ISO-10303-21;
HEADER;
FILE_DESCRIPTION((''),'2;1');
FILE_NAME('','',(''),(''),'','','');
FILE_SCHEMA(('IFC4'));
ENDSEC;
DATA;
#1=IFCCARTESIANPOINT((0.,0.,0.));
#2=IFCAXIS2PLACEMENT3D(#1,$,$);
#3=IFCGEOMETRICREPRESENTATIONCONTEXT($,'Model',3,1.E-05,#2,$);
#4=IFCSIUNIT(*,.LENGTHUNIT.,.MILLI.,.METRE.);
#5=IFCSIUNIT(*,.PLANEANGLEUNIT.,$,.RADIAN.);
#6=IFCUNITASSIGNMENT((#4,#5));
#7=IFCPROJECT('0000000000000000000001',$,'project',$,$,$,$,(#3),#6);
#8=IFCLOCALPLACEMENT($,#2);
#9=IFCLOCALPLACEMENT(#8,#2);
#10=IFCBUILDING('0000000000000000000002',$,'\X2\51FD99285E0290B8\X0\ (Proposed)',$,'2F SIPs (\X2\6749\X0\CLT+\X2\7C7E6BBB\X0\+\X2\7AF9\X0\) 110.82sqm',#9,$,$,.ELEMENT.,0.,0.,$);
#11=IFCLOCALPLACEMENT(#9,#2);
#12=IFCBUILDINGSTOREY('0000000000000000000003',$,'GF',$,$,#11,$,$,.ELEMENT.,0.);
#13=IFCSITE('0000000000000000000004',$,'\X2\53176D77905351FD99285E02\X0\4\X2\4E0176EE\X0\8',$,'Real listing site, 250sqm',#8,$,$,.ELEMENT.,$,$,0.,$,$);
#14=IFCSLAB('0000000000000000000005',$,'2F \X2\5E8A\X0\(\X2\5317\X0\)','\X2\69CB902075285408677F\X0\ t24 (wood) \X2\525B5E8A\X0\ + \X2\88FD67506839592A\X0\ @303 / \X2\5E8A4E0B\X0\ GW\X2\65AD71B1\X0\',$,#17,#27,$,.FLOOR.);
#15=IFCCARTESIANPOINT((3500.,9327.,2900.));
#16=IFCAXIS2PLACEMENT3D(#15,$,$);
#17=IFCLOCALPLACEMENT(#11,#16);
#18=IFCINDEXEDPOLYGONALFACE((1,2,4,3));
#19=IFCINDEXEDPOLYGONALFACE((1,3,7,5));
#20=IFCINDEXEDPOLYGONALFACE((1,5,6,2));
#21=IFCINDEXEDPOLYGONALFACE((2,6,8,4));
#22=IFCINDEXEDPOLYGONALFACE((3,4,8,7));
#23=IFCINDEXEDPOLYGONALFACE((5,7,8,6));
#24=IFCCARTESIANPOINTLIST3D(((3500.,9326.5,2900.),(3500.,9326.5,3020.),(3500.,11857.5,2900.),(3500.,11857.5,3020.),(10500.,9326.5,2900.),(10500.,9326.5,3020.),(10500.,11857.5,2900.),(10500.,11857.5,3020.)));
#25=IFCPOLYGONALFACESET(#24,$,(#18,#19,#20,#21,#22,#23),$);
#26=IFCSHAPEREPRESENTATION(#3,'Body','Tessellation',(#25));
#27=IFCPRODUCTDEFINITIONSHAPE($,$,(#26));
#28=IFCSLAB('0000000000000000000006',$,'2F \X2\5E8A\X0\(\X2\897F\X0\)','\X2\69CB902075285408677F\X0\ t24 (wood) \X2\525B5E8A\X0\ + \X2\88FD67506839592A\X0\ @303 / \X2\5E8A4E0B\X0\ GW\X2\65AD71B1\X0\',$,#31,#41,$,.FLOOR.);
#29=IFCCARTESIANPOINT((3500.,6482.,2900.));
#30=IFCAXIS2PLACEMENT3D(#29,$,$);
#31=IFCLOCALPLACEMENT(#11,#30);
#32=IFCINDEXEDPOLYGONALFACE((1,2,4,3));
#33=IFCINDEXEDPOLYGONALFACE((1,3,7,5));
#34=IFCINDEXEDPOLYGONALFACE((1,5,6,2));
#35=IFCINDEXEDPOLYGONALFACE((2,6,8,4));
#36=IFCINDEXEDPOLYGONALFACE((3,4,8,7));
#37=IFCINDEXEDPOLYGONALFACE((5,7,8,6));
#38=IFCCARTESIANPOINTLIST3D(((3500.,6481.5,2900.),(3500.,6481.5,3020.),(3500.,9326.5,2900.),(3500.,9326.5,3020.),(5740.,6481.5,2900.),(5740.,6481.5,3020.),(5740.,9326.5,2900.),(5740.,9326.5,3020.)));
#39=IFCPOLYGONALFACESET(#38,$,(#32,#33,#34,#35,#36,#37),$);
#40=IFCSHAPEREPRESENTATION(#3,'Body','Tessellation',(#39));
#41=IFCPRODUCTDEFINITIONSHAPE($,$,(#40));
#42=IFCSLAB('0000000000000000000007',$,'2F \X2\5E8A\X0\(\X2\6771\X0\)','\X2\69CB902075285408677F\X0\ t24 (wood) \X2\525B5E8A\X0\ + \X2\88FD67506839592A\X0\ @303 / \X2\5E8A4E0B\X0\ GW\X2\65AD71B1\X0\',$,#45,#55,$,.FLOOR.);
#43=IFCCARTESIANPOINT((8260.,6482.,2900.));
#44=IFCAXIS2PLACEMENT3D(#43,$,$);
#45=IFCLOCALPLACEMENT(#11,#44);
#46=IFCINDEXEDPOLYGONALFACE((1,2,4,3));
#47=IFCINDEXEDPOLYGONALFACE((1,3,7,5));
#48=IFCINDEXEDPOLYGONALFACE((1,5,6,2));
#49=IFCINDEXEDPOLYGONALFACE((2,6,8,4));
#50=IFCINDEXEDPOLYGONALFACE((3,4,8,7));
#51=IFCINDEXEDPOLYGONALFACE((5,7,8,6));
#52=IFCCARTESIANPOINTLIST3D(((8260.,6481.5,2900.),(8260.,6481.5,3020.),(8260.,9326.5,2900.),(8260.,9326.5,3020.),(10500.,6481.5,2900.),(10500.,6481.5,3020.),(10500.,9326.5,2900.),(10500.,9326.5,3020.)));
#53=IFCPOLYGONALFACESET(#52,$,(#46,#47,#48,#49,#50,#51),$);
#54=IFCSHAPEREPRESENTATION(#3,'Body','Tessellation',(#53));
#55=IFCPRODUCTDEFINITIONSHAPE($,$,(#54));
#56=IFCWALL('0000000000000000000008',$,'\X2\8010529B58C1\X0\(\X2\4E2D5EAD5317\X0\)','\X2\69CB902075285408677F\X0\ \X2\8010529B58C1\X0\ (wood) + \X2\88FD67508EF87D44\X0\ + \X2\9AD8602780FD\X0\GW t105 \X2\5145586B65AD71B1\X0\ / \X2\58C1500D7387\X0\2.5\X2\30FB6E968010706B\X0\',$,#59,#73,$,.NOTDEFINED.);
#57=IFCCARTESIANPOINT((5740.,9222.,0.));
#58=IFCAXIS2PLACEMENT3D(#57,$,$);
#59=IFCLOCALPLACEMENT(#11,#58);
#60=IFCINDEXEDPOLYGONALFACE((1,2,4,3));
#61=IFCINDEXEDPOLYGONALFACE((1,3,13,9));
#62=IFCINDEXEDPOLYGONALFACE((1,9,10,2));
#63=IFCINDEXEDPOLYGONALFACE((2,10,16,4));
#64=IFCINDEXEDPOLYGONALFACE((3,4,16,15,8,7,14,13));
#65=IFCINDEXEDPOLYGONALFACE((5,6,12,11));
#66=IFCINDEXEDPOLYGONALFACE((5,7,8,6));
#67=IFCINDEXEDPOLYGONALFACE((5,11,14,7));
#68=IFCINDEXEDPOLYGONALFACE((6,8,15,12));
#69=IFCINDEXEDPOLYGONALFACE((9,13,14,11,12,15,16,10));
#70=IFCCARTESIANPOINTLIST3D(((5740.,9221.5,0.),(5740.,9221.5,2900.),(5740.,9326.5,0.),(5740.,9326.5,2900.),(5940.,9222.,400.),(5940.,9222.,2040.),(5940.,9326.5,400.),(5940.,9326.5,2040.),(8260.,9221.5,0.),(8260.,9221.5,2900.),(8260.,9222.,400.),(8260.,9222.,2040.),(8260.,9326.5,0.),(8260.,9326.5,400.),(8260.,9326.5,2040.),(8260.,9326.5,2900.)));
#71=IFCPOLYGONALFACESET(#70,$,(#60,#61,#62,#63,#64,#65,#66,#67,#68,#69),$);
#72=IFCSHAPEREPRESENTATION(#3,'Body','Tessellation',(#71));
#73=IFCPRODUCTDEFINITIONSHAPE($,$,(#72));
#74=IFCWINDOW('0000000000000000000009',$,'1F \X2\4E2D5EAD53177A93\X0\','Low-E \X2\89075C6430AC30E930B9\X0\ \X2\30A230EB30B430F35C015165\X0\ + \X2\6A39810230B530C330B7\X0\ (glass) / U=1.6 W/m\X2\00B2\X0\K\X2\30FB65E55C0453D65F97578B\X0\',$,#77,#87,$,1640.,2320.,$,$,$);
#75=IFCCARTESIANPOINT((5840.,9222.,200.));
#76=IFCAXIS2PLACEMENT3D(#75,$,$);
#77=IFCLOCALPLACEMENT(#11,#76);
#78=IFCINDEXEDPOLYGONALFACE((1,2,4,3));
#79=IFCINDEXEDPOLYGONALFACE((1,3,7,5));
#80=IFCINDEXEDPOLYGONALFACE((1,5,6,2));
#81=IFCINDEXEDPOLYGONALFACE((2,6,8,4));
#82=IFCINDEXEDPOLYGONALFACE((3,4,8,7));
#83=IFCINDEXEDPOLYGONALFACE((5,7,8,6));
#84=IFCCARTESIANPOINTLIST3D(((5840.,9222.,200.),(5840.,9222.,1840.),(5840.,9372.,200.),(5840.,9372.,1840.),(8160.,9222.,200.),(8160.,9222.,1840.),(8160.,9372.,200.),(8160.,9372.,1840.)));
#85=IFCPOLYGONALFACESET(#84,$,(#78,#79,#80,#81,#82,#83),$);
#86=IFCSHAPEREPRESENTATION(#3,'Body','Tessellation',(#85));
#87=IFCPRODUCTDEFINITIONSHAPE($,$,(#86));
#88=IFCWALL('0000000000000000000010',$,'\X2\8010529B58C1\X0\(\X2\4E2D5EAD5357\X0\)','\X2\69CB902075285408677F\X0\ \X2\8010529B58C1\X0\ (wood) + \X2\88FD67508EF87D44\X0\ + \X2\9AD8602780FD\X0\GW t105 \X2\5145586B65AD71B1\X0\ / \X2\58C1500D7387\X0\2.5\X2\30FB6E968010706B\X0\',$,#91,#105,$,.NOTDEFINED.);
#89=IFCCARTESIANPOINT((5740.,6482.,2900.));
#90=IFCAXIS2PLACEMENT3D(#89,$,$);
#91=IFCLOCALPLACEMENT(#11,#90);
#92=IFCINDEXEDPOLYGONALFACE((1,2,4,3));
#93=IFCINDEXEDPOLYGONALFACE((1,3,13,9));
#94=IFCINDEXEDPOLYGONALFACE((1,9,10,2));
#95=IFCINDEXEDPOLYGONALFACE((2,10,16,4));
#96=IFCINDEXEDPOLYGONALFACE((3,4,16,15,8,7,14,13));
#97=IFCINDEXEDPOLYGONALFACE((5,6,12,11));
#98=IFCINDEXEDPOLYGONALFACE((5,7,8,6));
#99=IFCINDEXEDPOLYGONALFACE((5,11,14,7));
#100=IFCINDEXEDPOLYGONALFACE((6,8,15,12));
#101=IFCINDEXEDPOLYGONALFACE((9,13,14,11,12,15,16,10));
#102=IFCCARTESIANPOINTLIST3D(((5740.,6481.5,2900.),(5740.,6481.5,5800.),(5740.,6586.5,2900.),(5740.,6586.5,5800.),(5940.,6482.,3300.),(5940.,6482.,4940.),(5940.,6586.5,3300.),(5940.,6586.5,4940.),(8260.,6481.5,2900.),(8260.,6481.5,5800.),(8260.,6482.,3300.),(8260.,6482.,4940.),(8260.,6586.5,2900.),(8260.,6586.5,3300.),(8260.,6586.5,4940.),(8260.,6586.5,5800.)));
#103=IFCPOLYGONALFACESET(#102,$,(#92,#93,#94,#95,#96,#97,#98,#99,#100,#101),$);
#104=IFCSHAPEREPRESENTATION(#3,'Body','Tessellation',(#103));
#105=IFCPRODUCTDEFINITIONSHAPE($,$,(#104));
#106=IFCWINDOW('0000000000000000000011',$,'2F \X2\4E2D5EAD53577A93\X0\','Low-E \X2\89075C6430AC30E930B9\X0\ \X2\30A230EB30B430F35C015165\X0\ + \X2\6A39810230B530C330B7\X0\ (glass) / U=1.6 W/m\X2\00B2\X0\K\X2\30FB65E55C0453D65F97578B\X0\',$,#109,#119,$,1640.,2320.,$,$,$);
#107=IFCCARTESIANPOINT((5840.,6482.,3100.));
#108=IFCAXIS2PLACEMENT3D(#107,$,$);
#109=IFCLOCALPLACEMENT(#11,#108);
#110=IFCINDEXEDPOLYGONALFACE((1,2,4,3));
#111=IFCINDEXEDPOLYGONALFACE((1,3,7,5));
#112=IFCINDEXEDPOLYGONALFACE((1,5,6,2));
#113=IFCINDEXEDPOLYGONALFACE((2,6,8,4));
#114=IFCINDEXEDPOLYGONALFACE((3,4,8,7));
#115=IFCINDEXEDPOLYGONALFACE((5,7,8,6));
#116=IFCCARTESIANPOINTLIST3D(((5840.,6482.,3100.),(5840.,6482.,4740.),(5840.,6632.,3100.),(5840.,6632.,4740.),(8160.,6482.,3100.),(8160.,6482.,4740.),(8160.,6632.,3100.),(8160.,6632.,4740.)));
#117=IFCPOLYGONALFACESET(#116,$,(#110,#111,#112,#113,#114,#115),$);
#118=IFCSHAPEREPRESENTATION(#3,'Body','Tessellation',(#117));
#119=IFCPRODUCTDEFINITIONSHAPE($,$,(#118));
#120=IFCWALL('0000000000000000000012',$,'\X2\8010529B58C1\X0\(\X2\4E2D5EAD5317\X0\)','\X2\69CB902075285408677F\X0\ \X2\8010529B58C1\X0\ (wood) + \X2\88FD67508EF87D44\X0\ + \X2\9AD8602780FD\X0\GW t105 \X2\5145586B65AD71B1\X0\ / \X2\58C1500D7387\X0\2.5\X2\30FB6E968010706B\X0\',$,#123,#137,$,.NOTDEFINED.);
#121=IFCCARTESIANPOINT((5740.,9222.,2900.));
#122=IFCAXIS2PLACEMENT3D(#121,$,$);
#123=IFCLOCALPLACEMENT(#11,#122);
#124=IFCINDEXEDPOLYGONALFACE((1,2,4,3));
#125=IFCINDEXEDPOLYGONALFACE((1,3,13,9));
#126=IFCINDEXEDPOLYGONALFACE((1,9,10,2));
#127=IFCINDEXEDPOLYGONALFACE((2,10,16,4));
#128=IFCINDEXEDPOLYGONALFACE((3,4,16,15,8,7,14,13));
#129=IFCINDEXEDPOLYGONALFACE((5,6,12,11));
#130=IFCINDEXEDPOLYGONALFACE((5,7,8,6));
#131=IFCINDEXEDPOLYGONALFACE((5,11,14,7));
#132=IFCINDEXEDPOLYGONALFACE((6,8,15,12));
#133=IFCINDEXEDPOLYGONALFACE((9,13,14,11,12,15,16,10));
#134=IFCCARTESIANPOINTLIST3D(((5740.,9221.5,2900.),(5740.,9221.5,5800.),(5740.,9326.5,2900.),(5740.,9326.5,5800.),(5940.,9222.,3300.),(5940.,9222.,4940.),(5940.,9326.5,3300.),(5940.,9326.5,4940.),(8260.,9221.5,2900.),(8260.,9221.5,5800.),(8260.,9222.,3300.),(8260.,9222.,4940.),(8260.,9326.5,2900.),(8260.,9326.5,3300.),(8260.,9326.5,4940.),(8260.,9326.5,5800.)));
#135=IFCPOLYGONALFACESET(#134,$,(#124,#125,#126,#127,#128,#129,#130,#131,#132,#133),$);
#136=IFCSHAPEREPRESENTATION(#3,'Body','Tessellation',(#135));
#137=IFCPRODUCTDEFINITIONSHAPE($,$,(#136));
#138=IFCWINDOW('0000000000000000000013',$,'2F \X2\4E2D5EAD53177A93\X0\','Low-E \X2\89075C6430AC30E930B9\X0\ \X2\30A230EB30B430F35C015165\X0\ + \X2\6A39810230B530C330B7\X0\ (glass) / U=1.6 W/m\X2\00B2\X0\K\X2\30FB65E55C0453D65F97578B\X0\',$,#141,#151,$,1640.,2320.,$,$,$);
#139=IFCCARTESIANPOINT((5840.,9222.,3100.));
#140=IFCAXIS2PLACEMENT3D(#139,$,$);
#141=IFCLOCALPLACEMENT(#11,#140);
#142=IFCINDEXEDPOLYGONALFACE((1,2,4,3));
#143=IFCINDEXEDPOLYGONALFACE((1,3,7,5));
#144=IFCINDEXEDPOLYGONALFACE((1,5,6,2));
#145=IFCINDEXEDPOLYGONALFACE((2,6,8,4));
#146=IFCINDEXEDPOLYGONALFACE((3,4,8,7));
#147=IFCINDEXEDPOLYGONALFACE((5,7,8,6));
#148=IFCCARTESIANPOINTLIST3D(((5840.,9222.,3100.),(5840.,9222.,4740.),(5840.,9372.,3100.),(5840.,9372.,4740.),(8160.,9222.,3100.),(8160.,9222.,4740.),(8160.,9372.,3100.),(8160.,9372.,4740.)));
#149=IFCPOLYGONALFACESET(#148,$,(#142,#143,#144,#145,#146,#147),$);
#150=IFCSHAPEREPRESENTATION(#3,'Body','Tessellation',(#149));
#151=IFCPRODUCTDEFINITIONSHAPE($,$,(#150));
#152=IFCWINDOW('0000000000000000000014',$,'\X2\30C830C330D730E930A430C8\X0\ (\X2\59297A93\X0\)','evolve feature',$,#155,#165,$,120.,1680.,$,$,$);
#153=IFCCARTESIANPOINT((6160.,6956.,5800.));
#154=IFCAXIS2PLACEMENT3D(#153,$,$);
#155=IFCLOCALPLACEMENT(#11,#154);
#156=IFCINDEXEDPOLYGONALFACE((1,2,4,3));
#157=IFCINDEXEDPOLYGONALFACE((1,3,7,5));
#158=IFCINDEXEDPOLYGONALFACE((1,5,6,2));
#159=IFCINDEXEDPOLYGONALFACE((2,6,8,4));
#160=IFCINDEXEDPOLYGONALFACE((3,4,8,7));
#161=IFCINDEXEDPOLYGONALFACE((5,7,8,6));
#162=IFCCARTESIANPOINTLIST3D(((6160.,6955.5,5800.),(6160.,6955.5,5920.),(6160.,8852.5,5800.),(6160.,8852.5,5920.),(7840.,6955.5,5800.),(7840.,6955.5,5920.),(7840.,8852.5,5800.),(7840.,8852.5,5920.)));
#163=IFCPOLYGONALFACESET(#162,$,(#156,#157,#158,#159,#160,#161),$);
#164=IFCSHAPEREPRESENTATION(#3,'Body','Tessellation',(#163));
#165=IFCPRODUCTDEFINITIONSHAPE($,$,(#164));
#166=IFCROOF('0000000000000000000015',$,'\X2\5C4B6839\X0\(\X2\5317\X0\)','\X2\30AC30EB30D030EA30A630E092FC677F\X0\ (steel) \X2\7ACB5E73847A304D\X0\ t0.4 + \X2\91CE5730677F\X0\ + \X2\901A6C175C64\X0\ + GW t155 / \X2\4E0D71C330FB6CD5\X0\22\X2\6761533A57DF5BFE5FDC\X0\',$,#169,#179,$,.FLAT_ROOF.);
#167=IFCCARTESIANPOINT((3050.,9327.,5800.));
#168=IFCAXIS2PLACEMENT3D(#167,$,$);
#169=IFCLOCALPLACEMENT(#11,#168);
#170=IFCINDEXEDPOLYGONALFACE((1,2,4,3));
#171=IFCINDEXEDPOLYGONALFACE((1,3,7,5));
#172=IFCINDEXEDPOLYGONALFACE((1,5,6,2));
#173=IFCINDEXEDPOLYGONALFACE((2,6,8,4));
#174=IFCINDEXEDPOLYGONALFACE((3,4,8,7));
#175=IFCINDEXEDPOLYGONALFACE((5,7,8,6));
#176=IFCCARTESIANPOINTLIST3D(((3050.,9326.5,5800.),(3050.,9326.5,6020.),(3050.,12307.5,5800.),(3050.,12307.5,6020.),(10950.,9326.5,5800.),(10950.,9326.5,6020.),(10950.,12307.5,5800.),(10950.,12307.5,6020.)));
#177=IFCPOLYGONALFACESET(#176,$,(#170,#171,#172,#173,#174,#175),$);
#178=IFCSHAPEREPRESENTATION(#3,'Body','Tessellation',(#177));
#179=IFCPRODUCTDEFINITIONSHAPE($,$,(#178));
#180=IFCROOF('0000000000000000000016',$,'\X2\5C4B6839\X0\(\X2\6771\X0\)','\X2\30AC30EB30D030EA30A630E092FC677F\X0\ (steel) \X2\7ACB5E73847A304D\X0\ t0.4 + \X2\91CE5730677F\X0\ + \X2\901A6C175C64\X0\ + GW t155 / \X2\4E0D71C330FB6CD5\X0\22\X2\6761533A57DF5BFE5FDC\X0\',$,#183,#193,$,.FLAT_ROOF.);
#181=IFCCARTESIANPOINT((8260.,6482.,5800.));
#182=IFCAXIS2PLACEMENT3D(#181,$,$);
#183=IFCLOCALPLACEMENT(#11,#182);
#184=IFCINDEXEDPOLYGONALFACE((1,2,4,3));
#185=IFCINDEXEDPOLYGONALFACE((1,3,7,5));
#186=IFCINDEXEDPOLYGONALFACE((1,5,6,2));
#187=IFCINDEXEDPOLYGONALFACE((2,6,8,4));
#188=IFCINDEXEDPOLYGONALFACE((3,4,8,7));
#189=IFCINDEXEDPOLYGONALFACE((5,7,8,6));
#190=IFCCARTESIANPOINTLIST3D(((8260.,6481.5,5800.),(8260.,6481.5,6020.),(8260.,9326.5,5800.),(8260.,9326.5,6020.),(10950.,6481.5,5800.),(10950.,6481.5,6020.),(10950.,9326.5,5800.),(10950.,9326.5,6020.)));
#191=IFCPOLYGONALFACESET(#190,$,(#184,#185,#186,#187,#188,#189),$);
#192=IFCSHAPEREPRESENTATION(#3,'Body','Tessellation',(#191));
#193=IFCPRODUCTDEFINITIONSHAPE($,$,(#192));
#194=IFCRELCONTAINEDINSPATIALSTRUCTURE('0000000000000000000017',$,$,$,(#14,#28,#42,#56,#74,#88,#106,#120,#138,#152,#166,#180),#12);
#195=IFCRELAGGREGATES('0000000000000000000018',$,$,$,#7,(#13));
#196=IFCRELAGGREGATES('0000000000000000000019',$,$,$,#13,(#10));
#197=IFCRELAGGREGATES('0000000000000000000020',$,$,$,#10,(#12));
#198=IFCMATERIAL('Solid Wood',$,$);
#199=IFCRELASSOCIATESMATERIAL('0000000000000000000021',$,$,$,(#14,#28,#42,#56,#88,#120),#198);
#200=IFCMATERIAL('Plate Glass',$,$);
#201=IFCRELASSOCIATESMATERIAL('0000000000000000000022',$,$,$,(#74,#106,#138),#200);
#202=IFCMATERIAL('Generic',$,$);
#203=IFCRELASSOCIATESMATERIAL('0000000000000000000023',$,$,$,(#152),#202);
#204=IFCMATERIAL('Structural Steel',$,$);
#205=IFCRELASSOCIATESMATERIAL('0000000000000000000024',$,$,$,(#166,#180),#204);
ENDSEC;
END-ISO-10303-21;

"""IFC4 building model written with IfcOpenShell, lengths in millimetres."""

from ifc_helpers import new_model, si_unit, frame, frame_2d, origin, place, context, project, spatial, rectangle, extrude, material, element, fill, save


model = new_model("IFC4")

# Units and contexts
model_context = context("Model", 3, precision=1e-05, world=origin())
ifc_project = project(units=[si_unit("LENGTHUNIT", "METRE", prefix="MILLI"), si_unit("PLANEANGLEUNIT", "RADIAN")], contexts=[model_context])

# Site, building, storey
site_placement = place(None, origin())
site = spatial("IfcSite", under=ifc_project, at=site_placement, Name="北海道函館市4丁目8", ObjectType="Real listing site, 250sqm", CompositionType="ELEMENT", RefElevation=0.0)
building_placement = place(site_placement, origin())
building = spatial("IfcBuilding", under=site, at=building_placement, Name="函館市邸 (Proposed)", ObjectType="2F SIPs (杉CLT+籾殻+竹) 110.82sqm", CompositionType="ELEMENT", ElevationOfRefHeight=0.0, ElevationOfTerrain=0.0)
storey_placement = place(building_placement, origin())
storey = spatial("IfcBuildingStorey", under=building, at=storey_placement, Name="GF", CompositionType="ELEMENT", Elevation=0.0)

# Slabs
ifc_material_1 = material(Name="Solid Wood")
slab_1_placement = place(storey_placement, frame((3500.0, 9327.0, 2900.0)))
element("IfcSlab", 1, at=slab_1_placement, inside=storey, material=ifc_material_1, Name="2F 床(北)", Description="構造用合板 t24 (wood) 剛床 + 製材根太 @303 / 床下 GW断熱", PredefinedType="FLOOR", context=model_context, shape_type="SweptSolid", body=[
    extrude(rectangle(XDim=7000.0, YDim=2531.0, at=frame_2d((3500.0, 1265.0))), frame((3500.0, 9327.0, 2900.0)), (0.0, 0.0, 1.0), 120.0),
])
slab_2_placement = place(storey_placement, frame((3500.0, 6482.0, 2900.0)))
element("IfcSlab", 2, at=slab_2_placement, inside=storey, material=ifc_material_1, Name="2F 床(西)", Description="構造用合板 t24 (wood) 剛床 + 製材根太 @303 / 床下 GW断熱", PredefinedType="FLOOR", context=model_context, shape_type="SweptSolid", body=[
    extrude(rectangle(XDim=2240.0, YDim=2845.0, at=frame_2d((1120.0, 1422.0))), frame((3500.0, 6482.0, 2900.0)), (0.0, 0.0, 1.0), 120.0),
])
slab_3_placement = place(storey_placement, frame((8260.0, 6482.0, 2900.0)))
element("IfcSlab", 3, at=slab_3_placement, inside=storey, material=ifc_material_1, Name="2F 床(東)", Description="構造用合板 t24 (wood) 剛床 + 製材根太 @303 / 床下 GW断熱", PredefinedType="FLOOR", context=model_context, shape_type="SweptSolid", body=[
    extrude(rectangle(XDim=2240.0, YDim=2845.0, at=frame_2d((1120.0, 1422.0))), frame((8260.0, 6482.0, 2900.0)), (0.0, 0.0, 1.0), 120.0),
])

# Wall, opening, window
wall_1_placement = place(storey_placement, frame((5740.0, 9222.0, 0.0)))
wall_1 = element("IfcWall", 4, at=wall_1_placement, inside=storey, material=ifc_material_1, Name="耐力壁(中庭北)", Description="構造用合板 耐力壁 (wood) + 製材軸組 + 高性能GW t105 充填断熱 / 壁倍率2.5・準耐火", PredefinedType="NOTDEFINED", context=model_context, shape_type="SweptSolid", body=[
    extrude(rectangle(XDim=2520.0, YDim=105.0, at=frame_2d((1260.0, 52.0))), frame((5740.0, 9222.0, 0.0)), (0.0, 0.0, 1.0), 2900.0),
])
opening_1_placement = place(storey_placement, frame((5840.0, 9222.0, 200.0)))
opening_1 = element("IfcOpeningElement", 5, at=opening_1_placement, cuts=wall_1, PredefinedType="NOTDEFINED", context=model_context, shape_type="SweptSolid", body=[
    extrude(rectangle(XDim=2320.0, YDim=150.0, at=frame_2d((1160.0, 75.0))), frame((5840.0, 9222.0, 200.0)), (0.0, 0.0, 1.0), 1640.0),
])
ifc_material_2 = material(Name="Plate Glass")
window_1_placement = place(storey_placement, frame((5840.0, 9222.0, 200.0)))
window_1 = element("IfcWindow", 6, at=window_1_placement, inside=storey, material=ifc_material_2, Name="1F 中庭北窓", Description="Low-E 複層ガラス アルゴン封入 + 樹脂サッシ (glass) / U=1.6 W/m²K・日射取得型", OverallHeight=1640.0, OverallWidth=2320.0, context=model_context, shape_type="SweptSolid", body=[
    extrude(rectangle(XDim=2320.0, YDim=150.0, at=frame_2d((1160.0, 75.0))), frame((5840.0, 9222.0, 200.0)), (0.0, 0.0, 1.0), 1640.0),
])
fill(opening_1, window_1)

# Walls, openings, windows
wall_2_placement = place(storey_placement, frame((5740.0, 6482.0, 2900.0)))
wall_2 = element("IfcWall", 7, at=wall_2_placement, inside=storey, material=ifc_material_1, Name="耐力壁(中庭南)", Description="構造用合板 耐力壁 (wood) + 製材軸組 + 高性能GW t105 充填断熱 / 壁倍率2.5・準耐火", PredefinedType="NOTDEFINED", context=model_context, shape_type="SweptSolid", body=[
    extrude(rectangle(XDim=2520.0, YDim=105.0, at=frame_2d((1260.0, 52.0))), frame((5740.0, 6482.0, 2900.0)), (0.0, 0.0, 1.0), 2900.0),
])
opening_2_placement = place(storey_placement, frame((5840.0, 6482.0, 3100.0)))
opening_2 = element("IfcOpeningElement", 8, at=opening_2_placement, cuts=wall_2, PredefinedType="NOTDEFINED", context=model_context, shape_type="SweptSolid", body=[
    extrude(rectangle(XDim=2320.0, YDim=150.0, at=frame_2d((1160.0, 75.0))), frame((5840.0, 6482.0, 3100.0)), (0.0, 0.0, 1.0), 1640.0),
])
window_2_placement = place(storey_placement, frame((5840.0, 6482.0, 3100.0)))
window_2 = element("IfcWindow", 9, at=window_2_placement, inside=storey, material=ifc_material_2, Name="2F 中庭南窓", Description="Low-E 複層ガラス アルゴン封入 + 樹脂サッシ (glass) / U=1.6 W/m²K・日射取得型", OverallHeight=1640.0, OverallWidth=2320.0, context=model_context, shape_type="SweptSolid", body=[
    extrude(rectangle(XDim=2320.0, YDim=150.0, at=frame_2d((1160.0, 75.0))), frame((5840.0, 6482.0, 3100.0)), (0.0, 0.0, 1.0), 1640.0),
])
fill(opening_2, window_2)
wall_3_placement = place(storey_placement, frame((5740.0, 9222.0, 2900.0)))
wall_3 = element("IfcWall", 10, at=wall_3_placement, inside=storey, material=ifc_material_1, Name="耐力壁(中庭北)", Description="構造用合板 耐力壁 (wood) + 製材軸組 + 高性能GW t105 充填断熱 / 壁倍率2.5・準耐火", PredefinedType="NOTDEFINED", context=model_context, shape_type="SweptSolid", body=[
    extrude(rectangle(XDim=2520.0, YDim=105.0, at=frame_2d((1260.0, 52.0))), frame((5740.0, 9222.0, 2900.0)), (0.0, 0.0, 1.0), 2900.0),
])
opening_3_placement = place(storey_placement, frame((5840.0, 9222.0, 3100.0)))
opening_3 = element("IfcOpeningElement", 11, at=opening_3_placement, cuts=wall_3, PredefinedType="NOTDEFINED", context=model_context, shape_type="SweptSolid", body=[
    extrude(rectangle(XDim=2320.0, YDim=150.0, at=frame_2d((1160.0, 75.0))), frame((5840.0, 9222.0, 3100.0)), (0.0, 0.0, 1.0), 1640.0),
])
window_3_placement = place(storey_placement, frame((5840.0, 9222.0, 3100.0)))
window_3 = element("IfcWindow", 12, at=window_3_placement, inside=storey, material=ifc_material_2, Name="2F 中庭北窓", Description="Low-E 複層ガラス アルゴン封入 + 樹脂サッシ (glass) / U=1.6 W/m²K・日射取得型", OverallHeight=1640.0, OverallWidth=2320.0, context=model_context, shape_type="SweptSolid", body=[
    extrude(rectangle(XDim=2320.0, YDim=150.0, at=frame_2d((1160.0, 75.0))), frame((5840.0, 9222.0, 3100.0)), (0.0, 0.0, 1.0), 1640.0),
])
fill(opening_3, window_3)

# Window
ifc_material_3 = material(Name="Generic")
window_4_placement = place(storey_placement, frame((6160.0, 6956.0, 5800.0)))
element("IfcWindow", 13, at=window_4_placement, inside=storey, material=ifc_material_3, Name="トップライト (天窓)", Description="evolve feature", OverallHeight=120.0, OverallWidth=1680.0, context=model_context, shape_type="SweptSolid", body=[
    extrude(rectangle(XDim=1680.0, YDim=1897.0, at=frame_2d((840.0, 948.0))), frame((6160.0, 6956.0, 5800.0)), (0.0, 0.0, 1.0), 120.0),
])

# Roofs
ifc_material_4 = material(Name="Structural Steel")
roof_1_placement = place(storey_placement, frame((3050.0, 9327.0, 5800.0)))
element("IfcRoof", 14, at=roof_1_placement, inside=storey, material=ifc_material_4, Name="屋根(北)", Description="ガルバリウム鋼板 (steel) 立平葺き t0.4 + 野地板 + 通気層 + GW t155 / 不燃・法22条区域対応", PredefinedType="FLAT_ROOF", context=model_context, shape_type="SweptSolid", body=[
    extrude(rectangle(XDim=7900.0, YDim=2981.0, at=frame_2d((3950.0, 1490.0))), frame((3050.0, 9327.0, 5800.0)), (0.0, 0.0, 1.0), 220.0),
])
roof_2_placement = place(storey_placement, frame((8260.0, 6482.0, 5800.0)))
element("IfcRoof", 15, at=roof_2_placement, inside=storey, material=ifc_material_4, Name="屋根(東)", Description="ガルバリウム鋼板 (steel) 立平葺き t0.4 + 野地板 + 通気層 + GW t155 / 不燃・法22条区域対応", PredefinedType="FLAT_ROOF", context=model_context, shape_type="SweptSolid", body=[
    extrude(rectangle(XDim=2690.0, YDim=2845.0, at=frame_2d((1345.0, 1422.0))), frame((8260.0, 6482.0, 5800.0)), (0.0, 0.0, 1.0), 220.0),
])

save(model, "model.ifc")
